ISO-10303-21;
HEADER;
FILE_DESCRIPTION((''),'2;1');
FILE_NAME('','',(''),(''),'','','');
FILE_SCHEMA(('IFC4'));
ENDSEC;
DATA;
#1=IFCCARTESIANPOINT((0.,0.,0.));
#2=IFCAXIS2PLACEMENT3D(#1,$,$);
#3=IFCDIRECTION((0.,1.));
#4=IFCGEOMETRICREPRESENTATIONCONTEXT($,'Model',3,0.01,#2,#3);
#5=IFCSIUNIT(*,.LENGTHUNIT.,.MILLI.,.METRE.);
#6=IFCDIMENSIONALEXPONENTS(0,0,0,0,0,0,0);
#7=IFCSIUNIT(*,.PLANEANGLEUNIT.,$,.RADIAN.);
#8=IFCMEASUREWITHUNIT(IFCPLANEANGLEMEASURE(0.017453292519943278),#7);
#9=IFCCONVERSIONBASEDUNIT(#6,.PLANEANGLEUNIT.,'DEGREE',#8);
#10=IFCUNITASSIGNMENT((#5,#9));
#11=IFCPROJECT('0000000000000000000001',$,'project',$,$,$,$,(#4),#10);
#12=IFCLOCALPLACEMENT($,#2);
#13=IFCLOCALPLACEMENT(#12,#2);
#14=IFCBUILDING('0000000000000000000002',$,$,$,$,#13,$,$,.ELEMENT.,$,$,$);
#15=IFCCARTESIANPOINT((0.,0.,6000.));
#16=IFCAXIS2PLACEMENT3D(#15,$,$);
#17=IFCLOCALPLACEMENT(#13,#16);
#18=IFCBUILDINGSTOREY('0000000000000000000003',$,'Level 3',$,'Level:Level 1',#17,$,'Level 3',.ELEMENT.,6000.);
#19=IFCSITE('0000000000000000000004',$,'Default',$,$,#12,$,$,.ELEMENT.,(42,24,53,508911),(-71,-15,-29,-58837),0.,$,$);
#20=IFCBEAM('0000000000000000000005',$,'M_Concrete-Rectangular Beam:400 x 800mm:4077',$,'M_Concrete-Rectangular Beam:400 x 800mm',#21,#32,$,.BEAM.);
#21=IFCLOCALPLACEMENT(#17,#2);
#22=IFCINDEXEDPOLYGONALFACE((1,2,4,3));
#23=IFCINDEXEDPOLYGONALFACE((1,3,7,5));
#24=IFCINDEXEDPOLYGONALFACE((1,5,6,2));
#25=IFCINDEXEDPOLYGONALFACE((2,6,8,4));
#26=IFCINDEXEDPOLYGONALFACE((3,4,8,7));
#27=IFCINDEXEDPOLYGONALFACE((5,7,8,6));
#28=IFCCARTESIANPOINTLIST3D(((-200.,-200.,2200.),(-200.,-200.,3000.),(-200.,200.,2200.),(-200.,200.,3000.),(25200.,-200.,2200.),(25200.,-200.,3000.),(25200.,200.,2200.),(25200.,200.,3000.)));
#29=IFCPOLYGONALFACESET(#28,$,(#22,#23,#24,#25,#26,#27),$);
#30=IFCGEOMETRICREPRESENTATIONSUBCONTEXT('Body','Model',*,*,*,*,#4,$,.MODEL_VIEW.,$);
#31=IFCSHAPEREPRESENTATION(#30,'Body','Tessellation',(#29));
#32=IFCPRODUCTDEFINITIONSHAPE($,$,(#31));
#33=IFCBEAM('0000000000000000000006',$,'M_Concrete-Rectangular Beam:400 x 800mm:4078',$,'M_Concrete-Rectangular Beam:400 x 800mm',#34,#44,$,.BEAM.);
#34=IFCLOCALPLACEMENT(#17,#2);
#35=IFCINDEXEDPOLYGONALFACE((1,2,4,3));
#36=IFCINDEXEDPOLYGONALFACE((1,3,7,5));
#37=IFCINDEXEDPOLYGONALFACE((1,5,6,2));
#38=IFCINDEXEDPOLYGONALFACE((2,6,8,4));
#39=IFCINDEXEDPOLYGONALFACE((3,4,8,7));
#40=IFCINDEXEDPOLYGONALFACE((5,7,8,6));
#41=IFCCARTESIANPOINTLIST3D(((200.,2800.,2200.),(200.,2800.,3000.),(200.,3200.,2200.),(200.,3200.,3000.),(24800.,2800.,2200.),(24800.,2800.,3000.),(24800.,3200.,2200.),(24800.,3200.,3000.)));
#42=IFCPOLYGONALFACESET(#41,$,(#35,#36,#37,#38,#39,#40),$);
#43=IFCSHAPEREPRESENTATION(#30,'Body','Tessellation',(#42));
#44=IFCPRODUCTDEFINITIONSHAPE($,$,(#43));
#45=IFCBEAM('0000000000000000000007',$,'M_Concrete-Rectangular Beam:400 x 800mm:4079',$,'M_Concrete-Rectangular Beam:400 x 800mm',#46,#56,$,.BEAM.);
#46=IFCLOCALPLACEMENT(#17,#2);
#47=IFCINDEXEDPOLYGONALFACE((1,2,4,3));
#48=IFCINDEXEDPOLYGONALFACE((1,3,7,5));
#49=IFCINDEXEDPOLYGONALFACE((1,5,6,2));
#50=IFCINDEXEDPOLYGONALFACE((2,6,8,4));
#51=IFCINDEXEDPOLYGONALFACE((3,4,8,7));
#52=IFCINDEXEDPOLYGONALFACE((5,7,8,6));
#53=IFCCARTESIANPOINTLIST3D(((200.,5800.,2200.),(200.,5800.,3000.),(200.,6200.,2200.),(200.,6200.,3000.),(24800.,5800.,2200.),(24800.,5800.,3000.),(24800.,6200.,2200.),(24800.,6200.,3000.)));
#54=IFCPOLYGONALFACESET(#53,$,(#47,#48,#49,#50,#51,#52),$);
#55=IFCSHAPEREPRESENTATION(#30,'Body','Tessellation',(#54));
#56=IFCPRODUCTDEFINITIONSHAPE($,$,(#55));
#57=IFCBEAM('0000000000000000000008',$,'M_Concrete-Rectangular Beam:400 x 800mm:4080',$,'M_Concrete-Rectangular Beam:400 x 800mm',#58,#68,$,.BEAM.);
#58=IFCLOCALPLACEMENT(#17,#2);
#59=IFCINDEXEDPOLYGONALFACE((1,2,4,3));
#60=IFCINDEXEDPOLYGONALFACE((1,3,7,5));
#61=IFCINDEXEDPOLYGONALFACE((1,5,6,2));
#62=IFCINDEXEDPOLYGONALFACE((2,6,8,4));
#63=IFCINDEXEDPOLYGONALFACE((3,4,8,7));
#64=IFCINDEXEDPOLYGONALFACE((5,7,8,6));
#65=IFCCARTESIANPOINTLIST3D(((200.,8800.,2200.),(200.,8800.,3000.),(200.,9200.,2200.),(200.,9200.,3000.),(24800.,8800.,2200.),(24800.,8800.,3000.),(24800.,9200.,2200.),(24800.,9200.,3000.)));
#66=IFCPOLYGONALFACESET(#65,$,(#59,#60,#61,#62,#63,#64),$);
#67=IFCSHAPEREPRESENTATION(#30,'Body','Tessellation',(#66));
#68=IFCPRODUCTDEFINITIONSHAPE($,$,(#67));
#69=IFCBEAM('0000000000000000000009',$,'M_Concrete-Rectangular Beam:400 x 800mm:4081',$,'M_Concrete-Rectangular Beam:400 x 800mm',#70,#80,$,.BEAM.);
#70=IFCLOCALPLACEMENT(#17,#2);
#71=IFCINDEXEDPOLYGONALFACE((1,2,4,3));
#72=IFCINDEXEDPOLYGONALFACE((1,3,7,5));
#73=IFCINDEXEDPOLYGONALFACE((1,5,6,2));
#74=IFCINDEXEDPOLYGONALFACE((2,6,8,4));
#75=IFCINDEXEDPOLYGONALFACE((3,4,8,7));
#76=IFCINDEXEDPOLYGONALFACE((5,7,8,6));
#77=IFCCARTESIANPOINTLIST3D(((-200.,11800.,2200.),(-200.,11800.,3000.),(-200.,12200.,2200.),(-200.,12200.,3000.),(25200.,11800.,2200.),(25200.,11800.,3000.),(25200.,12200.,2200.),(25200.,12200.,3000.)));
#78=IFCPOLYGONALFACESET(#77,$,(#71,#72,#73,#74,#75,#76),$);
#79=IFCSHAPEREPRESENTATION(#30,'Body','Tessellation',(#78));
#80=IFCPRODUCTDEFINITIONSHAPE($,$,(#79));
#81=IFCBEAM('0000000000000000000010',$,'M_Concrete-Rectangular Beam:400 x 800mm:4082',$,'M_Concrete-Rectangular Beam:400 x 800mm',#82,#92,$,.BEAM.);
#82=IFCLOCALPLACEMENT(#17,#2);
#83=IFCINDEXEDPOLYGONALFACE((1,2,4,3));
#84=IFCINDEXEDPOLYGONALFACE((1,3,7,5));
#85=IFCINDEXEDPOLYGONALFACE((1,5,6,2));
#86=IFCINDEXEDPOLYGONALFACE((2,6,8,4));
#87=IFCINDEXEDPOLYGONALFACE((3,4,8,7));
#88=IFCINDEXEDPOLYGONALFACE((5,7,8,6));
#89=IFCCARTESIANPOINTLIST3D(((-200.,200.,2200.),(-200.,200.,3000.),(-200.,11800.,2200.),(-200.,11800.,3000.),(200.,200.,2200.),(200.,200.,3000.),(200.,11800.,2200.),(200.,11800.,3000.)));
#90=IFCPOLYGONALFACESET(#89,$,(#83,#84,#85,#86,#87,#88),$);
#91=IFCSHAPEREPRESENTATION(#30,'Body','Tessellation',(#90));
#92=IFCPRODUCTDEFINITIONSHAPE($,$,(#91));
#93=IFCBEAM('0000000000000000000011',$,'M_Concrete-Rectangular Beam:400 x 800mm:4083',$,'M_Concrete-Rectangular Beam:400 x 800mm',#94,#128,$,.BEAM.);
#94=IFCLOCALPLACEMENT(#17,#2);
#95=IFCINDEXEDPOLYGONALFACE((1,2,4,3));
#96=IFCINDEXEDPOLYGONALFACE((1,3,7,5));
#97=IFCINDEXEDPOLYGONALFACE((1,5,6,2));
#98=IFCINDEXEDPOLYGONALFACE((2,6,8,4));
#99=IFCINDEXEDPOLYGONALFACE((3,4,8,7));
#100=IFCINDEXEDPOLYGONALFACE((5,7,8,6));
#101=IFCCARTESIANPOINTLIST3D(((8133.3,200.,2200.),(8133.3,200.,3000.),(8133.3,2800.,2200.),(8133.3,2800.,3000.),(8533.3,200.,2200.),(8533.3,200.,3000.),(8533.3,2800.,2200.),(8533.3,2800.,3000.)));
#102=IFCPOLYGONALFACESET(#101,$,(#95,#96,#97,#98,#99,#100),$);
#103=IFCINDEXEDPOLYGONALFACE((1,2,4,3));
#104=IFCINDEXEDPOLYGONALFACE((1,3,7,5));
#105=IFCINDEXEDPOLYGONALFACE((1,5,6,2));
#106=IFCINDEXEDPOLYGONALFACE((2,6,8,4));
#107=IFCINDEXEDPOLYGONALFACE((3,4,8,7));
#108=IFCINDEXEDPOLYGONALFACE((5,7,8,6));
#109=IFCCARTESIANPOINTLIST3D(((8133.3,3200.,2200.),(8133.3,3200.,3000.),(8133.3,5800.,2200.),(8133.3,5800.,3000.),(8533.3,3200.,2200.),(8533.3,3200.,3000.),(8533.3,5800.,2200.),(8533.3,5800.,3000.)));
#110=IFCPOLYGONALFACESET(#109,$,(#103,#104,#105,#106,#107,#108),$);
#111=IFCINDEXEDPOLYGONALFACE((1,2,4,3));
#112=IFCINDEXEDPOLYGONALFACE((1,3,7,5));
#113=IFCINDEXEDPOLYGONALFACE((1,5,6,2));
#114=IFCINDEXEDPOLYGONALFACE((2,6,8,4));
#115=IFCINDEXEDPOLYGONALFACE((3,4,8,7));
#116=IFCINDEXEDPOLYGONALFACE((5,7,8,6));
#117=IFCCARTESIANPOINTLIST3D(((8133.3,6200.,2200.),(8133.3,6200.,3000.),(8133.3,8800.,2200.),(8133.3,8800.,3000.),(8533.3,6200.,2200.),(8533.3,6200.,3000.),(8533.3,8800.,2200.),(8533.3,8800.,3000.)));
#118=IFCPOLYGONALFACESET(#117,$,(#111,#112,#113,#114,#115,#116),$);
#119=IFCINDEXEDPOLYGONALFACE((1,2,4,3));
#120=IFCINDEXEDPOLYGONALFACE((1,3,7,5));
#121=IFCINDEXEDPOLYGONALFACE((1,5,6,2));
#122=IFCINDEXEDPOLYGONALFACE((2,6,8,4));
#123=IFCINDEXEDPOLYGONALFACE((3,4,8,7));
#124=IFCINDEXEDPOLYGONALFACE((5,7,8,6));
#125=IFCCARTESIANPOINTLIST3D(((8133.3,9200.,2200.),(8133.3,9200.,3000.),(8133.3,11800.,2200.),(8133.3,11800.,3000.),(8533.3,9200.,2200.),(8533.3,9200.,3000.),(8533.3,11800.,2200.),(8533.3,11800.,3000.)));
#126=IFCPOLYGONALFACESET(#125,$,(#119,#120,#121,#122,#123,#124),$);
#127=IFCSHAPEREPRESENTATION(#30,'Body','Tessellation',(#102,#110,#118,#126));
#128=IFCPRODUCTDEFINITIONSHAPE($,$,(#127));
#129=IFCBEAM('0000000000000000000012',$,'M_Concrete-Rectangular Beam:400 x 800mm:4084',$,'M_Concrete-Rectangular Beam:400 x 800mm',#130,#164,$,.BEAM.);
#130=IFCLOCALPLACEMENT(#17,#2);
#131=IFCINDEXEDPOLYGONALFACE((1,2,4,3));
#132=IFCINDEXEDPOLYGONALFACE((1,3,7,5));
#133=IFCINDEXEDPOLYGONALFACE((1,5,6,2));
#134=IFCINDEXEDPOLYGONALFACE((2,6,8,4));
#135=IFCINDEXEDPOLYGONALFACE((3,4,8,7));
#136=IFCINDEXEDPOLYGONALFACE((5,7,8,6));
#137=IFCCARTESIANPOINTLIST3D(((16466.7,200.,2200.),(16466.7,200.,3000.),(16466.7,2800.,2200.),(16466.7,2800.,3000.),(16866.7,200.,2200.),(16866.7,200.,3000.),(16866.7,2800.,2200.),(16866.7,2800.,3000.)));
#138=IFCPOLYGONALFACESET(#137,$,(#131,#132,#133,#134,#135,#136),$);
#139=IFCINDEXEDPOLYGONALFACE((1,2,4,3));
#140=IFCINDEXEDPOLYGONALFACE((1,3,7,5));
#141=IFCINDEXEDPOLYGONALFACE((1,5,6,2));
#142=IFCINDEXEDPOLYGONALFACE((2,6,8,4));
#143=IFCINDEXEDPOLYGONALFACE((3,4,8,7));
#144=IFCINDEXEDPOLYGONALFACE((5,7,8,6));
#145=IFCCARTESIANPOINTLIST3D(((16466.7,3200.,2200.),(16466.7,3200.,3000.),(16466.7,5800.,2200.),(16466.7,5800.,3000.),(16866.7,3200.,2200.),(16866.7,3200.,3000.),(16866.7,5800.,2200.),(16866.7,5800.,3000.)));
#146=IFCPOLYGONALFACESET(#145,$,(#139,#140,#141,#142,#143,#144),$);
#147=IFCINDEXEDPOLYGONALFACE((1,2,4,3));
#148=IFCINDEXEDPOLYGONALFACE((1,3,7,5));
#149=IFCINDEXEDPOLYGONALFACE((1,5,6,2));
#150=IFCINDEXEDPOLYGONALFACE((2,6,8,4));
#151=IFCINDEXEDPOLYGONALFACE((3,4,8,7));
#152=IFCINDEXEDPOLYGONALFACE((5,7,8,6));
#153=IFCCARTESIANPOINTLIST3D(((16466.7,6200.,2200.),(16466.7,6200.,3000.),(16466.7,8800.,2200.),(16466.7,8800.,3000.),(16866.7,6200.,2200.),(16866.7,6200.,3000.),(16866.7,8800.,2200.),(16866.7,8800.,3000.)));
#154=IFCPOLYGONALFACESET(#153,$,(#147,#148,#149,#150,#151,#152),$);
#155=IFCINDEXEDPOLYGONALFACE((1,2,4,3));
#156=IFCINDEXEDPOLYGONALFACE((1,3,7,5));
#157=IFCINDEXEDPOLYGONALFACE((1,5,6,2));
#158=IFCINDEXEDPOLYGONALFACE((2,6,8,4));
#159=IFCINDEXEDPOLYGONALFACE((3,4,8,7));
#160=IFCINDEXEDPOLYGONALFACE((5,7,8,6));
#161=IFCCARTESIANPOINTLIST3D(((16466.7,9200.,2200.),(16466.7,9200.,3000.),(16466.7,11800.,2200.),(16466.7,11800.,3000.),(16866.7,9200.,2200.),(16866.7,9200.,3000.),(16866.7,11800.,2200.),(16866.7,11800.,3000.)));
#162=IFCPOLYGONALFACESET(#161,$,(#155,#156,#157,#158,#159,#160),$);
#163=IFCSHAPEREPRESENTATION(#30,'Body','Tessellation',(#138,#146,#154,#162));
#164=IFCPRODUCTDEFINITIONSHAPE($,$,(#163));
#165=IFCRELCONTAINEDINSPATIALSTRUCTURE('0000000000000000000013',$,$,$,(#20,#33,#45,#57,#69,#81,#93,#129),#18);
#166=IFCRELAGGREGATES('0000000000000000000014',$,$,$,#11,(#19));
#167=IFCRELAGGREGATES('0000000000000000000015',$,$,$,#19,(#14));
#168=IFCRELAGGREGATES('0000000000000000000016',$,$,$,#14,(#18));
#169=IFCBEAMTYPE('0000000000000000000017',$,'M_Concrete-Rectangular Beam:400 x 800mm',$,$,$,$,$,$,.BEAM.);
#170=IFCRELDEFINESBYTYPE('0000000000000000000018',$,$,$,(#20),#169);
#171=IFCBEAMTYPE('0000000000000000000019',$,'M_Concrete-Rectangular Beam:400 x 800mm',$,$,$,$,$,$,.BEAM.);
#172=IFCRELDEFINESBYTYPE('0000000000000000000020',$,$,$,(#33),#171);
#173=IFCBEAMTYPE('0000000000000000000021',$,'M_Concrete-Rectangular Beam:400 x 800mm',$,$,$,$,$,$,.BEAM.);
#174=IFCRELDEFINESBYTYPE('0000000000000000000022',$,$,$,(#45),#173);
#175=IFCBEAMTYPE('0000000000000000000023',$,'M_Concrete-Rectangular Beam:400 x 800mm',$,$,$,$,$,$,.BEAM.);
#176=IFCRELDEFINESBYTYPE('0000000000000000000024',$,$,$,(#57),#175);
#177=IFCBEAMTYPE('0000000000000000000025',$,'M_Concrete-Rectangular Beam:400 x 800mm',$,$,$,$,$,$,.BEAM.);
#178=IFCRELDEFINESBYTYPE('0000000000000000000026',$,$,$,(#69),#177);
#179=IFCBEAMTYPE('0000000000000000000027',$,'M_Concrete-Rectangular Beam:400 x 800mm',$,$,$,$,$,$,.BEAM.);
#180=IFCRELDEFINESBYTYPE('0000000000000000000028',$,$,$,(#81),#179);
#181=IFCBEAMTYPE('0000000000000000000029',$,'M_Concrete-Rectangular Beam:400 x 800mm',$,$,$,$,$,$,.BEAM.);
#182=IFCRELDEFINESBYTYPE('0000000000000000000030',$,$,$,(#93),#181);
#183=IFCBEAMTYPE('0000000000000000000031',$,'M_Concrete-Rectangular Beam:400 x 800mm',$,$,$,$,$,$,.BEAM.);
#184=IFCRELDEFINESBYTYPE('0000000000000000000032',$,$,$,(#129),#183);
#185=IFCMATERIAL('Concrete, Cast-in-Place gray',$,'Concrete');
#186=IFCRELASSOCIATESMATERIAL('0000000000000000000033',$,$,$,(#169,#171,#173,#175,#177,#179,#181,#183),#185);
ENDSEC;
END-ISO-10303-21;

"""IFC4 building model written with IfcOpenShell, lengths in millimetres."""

from ifc_helpers import new_model, entity, si_unit, converted_unit, direction, frame, frame_2d, origin, origin_2d_with_axis, place, context, subcontext, project, spatial, rectangle, extrude, source, transform, mapped, material, material_profile, profile_set, type_object, type_shapes, element, save


model = new_model("IFC4")

# Units and contexts
model_context = context("Model", 3, precision=0.01, world=origin(), true_north=direction((0.0, 1.0)))
body_context = subcontext(model_context, "Body", "Model", "MODEL_VIEW")
ifc_project = project(units=[si_unit("LENGTHUNIT", "METRE", prefix="MILLI"), converted_unit("PLANEANGLEUNIT", "DEGREE", entity("IfcPlaneAngleMeasure", 0.017453292519943278), si_unit("PLANEANGLEUNIT", "RADIAN"), dimensions=[0, 0, 0, 0, 0, 0, 0])], contexts=[model_context])

# Site, building, storey
site_placement = place(None, origin())
site = spatial("IfcSite", under=ifc_project, at=site_placement, Name="Default", CompositionType="ELEMENT", RefLatitude=(42, 24, 53, 508911), RefLongitude=(-71, -15, -29, -58837), RefElevation=0.0)
building_placement = place(site_placement, origin())
building = spatial("IfcBuilding", under=site, at=building_placement, CompositionType="ELEMENT")
storey_placement = place(building_placement, frame((0.0, 0.0, 6000.0)))
storey = spatial("IfcBuildingStorey", under=building, at=storey_placement, Name="Level 3", ObjectType="Level:Level 1", LongName="Level 3", CompositionType="ELEMENT", Elevation=6000.0)

# Beams
ifc_material_1 = material(Name="Concrete, Cast-in-Place gray", Category="Concrete")
ifc_material_profile = material_profile(ifc_material_1, rectangle(XDim=800.0, YDim=400.0, at=origin_2d_with_axis()), Name="400 x 800mm")
ifc_profile_set = profile_set([ifc_material_profile], Name="400 x 800mm")
beam_type_1 = type_object("IfcBeamType", Name="M_Concrete-Rectangular Beam:400 x 800mm", PredefinedType="BEAM", material=ifc_profile_set)
shared_shape_1 = source(origin(), body_context, "Body", "SweptSolid", [
    extrude(rectangle(XDim=800.0, YDim=400.0, at=origin_2d_with_axis()), frame((-200.0, 0.0, 8600.0), z_axis=(1.0, 0.0, 0.0), x_axis=(0.0, 0.0, -1.0)), (0.0, 0.0, 1.0), 25400.0),
])
type_shapes(beam_type_1, [shared_shape_1])
beam_1_placement = place(storey_placement, frame((0.0, 0.0, -6000.0)))
element("IfcBeam", 1, at=beam_1_placement, inside=storey, type_object=beam_type_1, Name="M_Concrete-Rectangular Beam:400 x 800mm:4077", ObjectType="M_Concrete-Rectangular Beam:400 x 800mm", PredefinedType="BEAM", context=body_context, shape_type="MappedRepresentation", body=[
    mapped(shared_shape_1, transform((0.0, 0.0, 0.0), scale=1.0)),
])
beam_type_2 = type_object("IfcBeamType", Name="M_Concrete-Rectangular Beam:400 x 800mm", PredefinedType="BEAM", material=ifc_profile_set)
shared_shape_2 = source(origin(), body_context, "Body", "SweptSolid", [
    extrude(rectangle(XDim=800.0, YDim=400.0, at=origin_2d_with_axis()), frame((200.0, 3000.0, 8600.0), z_axis=(1.0, 0.0, 0.0), x_axis=(0.0, 0.0, -1.0)), (0.0, 0.0, 1.0), 24600.0),
])
type_shapes(beam_type_2, [shared_shape_2])
beam_2_placement = place(storey_placement, frame((0.0, 0.0, -6000.0)))
element("IfcBeam", 2, at=beam_2_placement, inside=storey, type_object=beam_type_2, Name="M_Concrete-Rectangular Beam:400 x 800mm:4078", ObjectType="M_Concrete-Rectangular Beam:400 x 800mm", PredefinedType="BEAM", context=body_context, shape_type="MappedRepresentation", body=[
    mapped(shared_shape_2, transform((0.0, 0.0, 0.0), scale=1.0)),
])
beam_type_3 = type_object("IfcBeamType", Name="M_Concrete-Rectangular Beam:400 x 800mm", PredefinedType="BEAM", material=ifc_profile_set)
shared_shape_3 = source(origin(), body_context, "Body", "SweptSolid", [
    extrude(rectangle(XDim=800.0, YDim=400.0, at=frame_2d((0.0, 0.0), x_axis=(1.0, 0.0))), frame((200.0, 6000.0, 8600.0), z_axis=(1.0, 0.0, 0.0), x_axis=(0.0, 0.0, -1.0)), (0.0, 0.0, 1.0), 24600.0),
])
type_shapes(beam_type_3, [shared_shape_3])
beam_3_placement = place(storey_placement, frame((0.0, 0.0, -6000.0)))
element("IfcBeam", 3, at=beam_3_placement, inside=storey, type_object=beam_type_3, Name="M_Concrete-Rectangular Beam:400 x 800mm:4079", ObjectType="M_Concrete-Rectangular Beam:400 x 800mm", PredefinedType="BEAM", context=body_context, shape_type="MappedRepresentation", body=[
    mapped(shared_shape_3, transform((0.0, 0.0, 0.0), scale=1.0)),
])
beam_type_4 = type_object("IfcBeamType", Name="M_Concrete-Rectangular Beam:400 x 800mm", PredefinedType="BEAM", material=ifc_profile_set)
shared_shape_4 = source(origin(), body_context, "Body", "SweptSolid", [
    extrude(rectangle(XDim=800.0, YDim=400.0, at=frame_2d((0.0, 0.0), x_axis=(1.0, 0.0))), frame((200.0, 9000.0, 8600.0), z_axis=(1.0, 0.0, 0.0), x_axis=(0.0, 0.0, -1.0)), (0.0, 0.0, 1.0), 24600.0),
])
type_shapes(beam_type_4, [shared_shape_4])
beam_4_placement = place(storey_placement, frame((0.0, 0.0, -6000.0)))
element("IfcBeam", 4, at=beam_4_placement, inside=storey, type_object=beam_type_4, Name="M_Concrete-Rectangular Beam:400 x 800mm:4080", ObjectType="M_Concrete-Rectangular Beam:400 x 800mm", PredefinedType="BEAM", context=body_context, shape_type="MappedRepresentation", body=[
    mapped(shared_shape_4, transform((0.0, 0.0, 0.0), scale=1.0)),
])
beam_type_5 = type_object("IfcBeamType", Name="M_Concrete-Rectangular Beam:400 x 800mm", PredefinedType="BEAM", material=ifc_profile_set)
shared_shape_5 = source(origin(), body_context, "Body", "SweptSolid", [
    extrude(rectangle(XDim=800.0, YDim=400.0, at=frame_2d((0.0, 0.0), x_axis=(1.0, 0.0))), frame((-200.0, 12000.0, 8600.0), z_axis=(1.0, 0.0, 0.0), x_axis=(0.0, 0.0, -1.0)), (0.0, 0.0, 1.0), 25400.0),
])
type_shapes(beam_type_5, [shared_shape_5])
beam_5_placement = place(storey_placement, frame((0.0, 0.0, -6000.0)))
element("IfcBeam", 5, at=beam_5_placement, inside=storey, type_object=beam_type_5, Name="M_Concrete-Rectangular Beam:400 x 800mm:4081", ObjectType="M_Concrete-Rectangular Beam:400 x 800mm", PredefinedType="BEAM", context=body_context, shape_type="MappedRepresentation", body=[
    mapped(shared_shape_5, transform((0.0, 0.0, 0.0), scale=1.0)),
])
beam_type_6 = type_object("IfcBeamType", Name="M_Concrete-Rectangular Beam:400 x 800mm", PredefinedType="BEAM", material=ifc_profile_set)
shared_shape_6 = source(origin(), body_context, "Body", "SweptSolid", [
    extrude(rectangle(XDim=800.0, YDim=400.0, at=frame_2d((0.0, 0.0), x_axis=(0.0, 1.0))), frame((0.0, 200.0, 8600.0), z_axis=(0.0, 1.0, 0.0), x_axis=(-1.0, 0.0, 0.0)), (0.0, 0.0, 1.0), 11600.0),
])
type_shapes(beam_type_6, [shared_shape_6])
beam_6_placement = place(storey_placement, frame((0.0, 0.0, -6000.0)))
element("IfcBeam", 6, at=beam_6_placement, inside=storey, type_object=beam_type_6, Name="M_Concrete-Rectangular Beam:400 x 800mm:4082", ObjectType="M_Concrete-Rectangular Beam:400 x 800mm", PredefinedType="BEAM", context=body_context, shape_type="MappedRepresentation", body=[
    mapped(shared_shape_6, transform((0.0, 0.0, 0.0), scale=1.0)),
])
beam_type_7 = type_object("IfcBeamType", Name="M_Concrete-Rectangular Beam:400 x 800mm", PredefinedType="BEAM", material=ifc_profile_set)
shared_shape_7 = source(origin(), body_context, "Body", "SweptSolid", [
    extrude(rectangle(XDim=800.0, YDim=400.0, at=frame_2d((0.0, 0.0), x_axis=(0.0, 1.0))), frame((8333.3, 200.0, 8600.0), z_axis=(0.0, 1.0, 0.0), x_axis=(-1.0, 0.0, 0.0)), (0.0, 0.0, 1.0), 2600.0),
    extrude(rectangle(XDim=800.0, YDim=400.0, at=frame_2d((0.0, 0.0), x_axis=(0.0, 1.0))), frame((8333.3, 3200.0, 8600.0), z_axis=(0.0, 1.0, 0.0), x_axis=(-1.0, 0.0, 0.0)), (0.0, 0.0, 1.0), 2600.0),
    extrude(rectangle(XDim=800.0, YDim=400.0, at=frame_2d((0.0, 0.0), x_axis=(0.0, 1.0))), frame((8333.3, 6200.0, 8600.0), z_axis=(0.0, 1.0, 0.0), x_axis=(-1.0, 0.0, 0.0)), (0.0, 0.0, 1.0), 2600.0),
    extrude(rectangle(XDim=800.0, YDim=400.0, at=frame_2d((0.0, 0.0), x_axis=(0.0, 1.0))), frame((8333.3, 9200.0, 8600.0), z_axis=(0.0, 1.0, 0.0), x_axis=(-1.0, 0.0, 0.0)), (0.0, 0.0, 1.0), 2600.0),
])
type_shapes(beam_type_7, [shared_shape_7])
beam_7_placement = place(storey_placement, frame((0.0, 0.0, -6000.0)))
element("IfcBeam", 7, at=beam_7_placement, inside=storey, type_object=beam_type_7, Name="M_Concrete-Rectangular Beam:400 x 800mm:4083", ObjectType="M_Concrete-Rectangular Beam:400 x 800mm", PredefinedType="BEAM", context=body_context, shape_type="MappedRepresentation", body=[
    mapped(shared_shape_7, transform((0.0, 0.0, 0.0), scale=1.0)),
])
beam_type_8 = type_object("IfcBeamType", Name="M_Concrete-Rectangular Beam:400 x 800mm", PredefinedType="BEAM", material=ifc_profile_set)
shared_shape_8 = source(origin(), body_context, "Body", "SweptSolid", [
    extrude(rectangle(XDim=800.0, YDim=400.0, at=frame_2d((0.0, 0.0), x_axis=(0.0, 1.0))), frame((16666.7, 200.0, 8600.0), z_axis=(0.0, 1.0, 0.0), x_axis=(-1.0, 0.0, 0.0)), (0.0, 0.0, 1.0), 2600.0),
    extrude(rectangle(XDim=800.0, YDim=400.0, at=frame_2d((0.0, 0.0), x_axis=(0.0, 1.0))), frame((16666.7, 3200.0, 8600.0), z_axis=(0.0, 1.0, 0.0), x_axis=(-1.0, 0.0, 0.0)), (0.0, 0.0, 1.0), 2600.0),
    extrude(rectangle(XDim=800.0, YDim=400.0, at=frame_2d((0.0, 0.0), x_axis=(0.0, 1.0))), frame((16666.7, 6200.0, 8600.0), z_axis=(0.0, 1.0, 0.0), x_axis=(-1.0, 0.0, 0.0)), (0.0, 0.0, 1.0), 2600.0),
    extrude(rectangle(XDim=800.0, YDim=400.0, at=frame_2d((0.0, 0.0), x_axis=(0.0, 1.0))), frame((16666.7, 9200.0, 8600.0), z_axis=(0.0, 1.0, 0.0), x_axis=(-1.0, 0.0, 0.0)), (0.0, 0.0, 1.0), 2600.0),
])
type_shapes(beam_type_8, [shared_shape_8])
beam_8_placement = place(storey_placement, frame((0.0, 0.0, -6000.0)))
element("IfcBeam", 8, at=beam_8_placement, inside=storey, type_object=beam_type_8, Name="M_Concrete-Rectangular Beam:400 x 800mm:4084", ObjectType="M_Concrete-Rectangular Beam:400 x 800mm", PredefinedType="BEAM", context=body_context, shape_type="MappedRepresentation", body=[
    mapped(shared_shape_8, transform((0.0, 0.0, 0.0), scale=1.0)),
])

save(model, "model.ifc")
